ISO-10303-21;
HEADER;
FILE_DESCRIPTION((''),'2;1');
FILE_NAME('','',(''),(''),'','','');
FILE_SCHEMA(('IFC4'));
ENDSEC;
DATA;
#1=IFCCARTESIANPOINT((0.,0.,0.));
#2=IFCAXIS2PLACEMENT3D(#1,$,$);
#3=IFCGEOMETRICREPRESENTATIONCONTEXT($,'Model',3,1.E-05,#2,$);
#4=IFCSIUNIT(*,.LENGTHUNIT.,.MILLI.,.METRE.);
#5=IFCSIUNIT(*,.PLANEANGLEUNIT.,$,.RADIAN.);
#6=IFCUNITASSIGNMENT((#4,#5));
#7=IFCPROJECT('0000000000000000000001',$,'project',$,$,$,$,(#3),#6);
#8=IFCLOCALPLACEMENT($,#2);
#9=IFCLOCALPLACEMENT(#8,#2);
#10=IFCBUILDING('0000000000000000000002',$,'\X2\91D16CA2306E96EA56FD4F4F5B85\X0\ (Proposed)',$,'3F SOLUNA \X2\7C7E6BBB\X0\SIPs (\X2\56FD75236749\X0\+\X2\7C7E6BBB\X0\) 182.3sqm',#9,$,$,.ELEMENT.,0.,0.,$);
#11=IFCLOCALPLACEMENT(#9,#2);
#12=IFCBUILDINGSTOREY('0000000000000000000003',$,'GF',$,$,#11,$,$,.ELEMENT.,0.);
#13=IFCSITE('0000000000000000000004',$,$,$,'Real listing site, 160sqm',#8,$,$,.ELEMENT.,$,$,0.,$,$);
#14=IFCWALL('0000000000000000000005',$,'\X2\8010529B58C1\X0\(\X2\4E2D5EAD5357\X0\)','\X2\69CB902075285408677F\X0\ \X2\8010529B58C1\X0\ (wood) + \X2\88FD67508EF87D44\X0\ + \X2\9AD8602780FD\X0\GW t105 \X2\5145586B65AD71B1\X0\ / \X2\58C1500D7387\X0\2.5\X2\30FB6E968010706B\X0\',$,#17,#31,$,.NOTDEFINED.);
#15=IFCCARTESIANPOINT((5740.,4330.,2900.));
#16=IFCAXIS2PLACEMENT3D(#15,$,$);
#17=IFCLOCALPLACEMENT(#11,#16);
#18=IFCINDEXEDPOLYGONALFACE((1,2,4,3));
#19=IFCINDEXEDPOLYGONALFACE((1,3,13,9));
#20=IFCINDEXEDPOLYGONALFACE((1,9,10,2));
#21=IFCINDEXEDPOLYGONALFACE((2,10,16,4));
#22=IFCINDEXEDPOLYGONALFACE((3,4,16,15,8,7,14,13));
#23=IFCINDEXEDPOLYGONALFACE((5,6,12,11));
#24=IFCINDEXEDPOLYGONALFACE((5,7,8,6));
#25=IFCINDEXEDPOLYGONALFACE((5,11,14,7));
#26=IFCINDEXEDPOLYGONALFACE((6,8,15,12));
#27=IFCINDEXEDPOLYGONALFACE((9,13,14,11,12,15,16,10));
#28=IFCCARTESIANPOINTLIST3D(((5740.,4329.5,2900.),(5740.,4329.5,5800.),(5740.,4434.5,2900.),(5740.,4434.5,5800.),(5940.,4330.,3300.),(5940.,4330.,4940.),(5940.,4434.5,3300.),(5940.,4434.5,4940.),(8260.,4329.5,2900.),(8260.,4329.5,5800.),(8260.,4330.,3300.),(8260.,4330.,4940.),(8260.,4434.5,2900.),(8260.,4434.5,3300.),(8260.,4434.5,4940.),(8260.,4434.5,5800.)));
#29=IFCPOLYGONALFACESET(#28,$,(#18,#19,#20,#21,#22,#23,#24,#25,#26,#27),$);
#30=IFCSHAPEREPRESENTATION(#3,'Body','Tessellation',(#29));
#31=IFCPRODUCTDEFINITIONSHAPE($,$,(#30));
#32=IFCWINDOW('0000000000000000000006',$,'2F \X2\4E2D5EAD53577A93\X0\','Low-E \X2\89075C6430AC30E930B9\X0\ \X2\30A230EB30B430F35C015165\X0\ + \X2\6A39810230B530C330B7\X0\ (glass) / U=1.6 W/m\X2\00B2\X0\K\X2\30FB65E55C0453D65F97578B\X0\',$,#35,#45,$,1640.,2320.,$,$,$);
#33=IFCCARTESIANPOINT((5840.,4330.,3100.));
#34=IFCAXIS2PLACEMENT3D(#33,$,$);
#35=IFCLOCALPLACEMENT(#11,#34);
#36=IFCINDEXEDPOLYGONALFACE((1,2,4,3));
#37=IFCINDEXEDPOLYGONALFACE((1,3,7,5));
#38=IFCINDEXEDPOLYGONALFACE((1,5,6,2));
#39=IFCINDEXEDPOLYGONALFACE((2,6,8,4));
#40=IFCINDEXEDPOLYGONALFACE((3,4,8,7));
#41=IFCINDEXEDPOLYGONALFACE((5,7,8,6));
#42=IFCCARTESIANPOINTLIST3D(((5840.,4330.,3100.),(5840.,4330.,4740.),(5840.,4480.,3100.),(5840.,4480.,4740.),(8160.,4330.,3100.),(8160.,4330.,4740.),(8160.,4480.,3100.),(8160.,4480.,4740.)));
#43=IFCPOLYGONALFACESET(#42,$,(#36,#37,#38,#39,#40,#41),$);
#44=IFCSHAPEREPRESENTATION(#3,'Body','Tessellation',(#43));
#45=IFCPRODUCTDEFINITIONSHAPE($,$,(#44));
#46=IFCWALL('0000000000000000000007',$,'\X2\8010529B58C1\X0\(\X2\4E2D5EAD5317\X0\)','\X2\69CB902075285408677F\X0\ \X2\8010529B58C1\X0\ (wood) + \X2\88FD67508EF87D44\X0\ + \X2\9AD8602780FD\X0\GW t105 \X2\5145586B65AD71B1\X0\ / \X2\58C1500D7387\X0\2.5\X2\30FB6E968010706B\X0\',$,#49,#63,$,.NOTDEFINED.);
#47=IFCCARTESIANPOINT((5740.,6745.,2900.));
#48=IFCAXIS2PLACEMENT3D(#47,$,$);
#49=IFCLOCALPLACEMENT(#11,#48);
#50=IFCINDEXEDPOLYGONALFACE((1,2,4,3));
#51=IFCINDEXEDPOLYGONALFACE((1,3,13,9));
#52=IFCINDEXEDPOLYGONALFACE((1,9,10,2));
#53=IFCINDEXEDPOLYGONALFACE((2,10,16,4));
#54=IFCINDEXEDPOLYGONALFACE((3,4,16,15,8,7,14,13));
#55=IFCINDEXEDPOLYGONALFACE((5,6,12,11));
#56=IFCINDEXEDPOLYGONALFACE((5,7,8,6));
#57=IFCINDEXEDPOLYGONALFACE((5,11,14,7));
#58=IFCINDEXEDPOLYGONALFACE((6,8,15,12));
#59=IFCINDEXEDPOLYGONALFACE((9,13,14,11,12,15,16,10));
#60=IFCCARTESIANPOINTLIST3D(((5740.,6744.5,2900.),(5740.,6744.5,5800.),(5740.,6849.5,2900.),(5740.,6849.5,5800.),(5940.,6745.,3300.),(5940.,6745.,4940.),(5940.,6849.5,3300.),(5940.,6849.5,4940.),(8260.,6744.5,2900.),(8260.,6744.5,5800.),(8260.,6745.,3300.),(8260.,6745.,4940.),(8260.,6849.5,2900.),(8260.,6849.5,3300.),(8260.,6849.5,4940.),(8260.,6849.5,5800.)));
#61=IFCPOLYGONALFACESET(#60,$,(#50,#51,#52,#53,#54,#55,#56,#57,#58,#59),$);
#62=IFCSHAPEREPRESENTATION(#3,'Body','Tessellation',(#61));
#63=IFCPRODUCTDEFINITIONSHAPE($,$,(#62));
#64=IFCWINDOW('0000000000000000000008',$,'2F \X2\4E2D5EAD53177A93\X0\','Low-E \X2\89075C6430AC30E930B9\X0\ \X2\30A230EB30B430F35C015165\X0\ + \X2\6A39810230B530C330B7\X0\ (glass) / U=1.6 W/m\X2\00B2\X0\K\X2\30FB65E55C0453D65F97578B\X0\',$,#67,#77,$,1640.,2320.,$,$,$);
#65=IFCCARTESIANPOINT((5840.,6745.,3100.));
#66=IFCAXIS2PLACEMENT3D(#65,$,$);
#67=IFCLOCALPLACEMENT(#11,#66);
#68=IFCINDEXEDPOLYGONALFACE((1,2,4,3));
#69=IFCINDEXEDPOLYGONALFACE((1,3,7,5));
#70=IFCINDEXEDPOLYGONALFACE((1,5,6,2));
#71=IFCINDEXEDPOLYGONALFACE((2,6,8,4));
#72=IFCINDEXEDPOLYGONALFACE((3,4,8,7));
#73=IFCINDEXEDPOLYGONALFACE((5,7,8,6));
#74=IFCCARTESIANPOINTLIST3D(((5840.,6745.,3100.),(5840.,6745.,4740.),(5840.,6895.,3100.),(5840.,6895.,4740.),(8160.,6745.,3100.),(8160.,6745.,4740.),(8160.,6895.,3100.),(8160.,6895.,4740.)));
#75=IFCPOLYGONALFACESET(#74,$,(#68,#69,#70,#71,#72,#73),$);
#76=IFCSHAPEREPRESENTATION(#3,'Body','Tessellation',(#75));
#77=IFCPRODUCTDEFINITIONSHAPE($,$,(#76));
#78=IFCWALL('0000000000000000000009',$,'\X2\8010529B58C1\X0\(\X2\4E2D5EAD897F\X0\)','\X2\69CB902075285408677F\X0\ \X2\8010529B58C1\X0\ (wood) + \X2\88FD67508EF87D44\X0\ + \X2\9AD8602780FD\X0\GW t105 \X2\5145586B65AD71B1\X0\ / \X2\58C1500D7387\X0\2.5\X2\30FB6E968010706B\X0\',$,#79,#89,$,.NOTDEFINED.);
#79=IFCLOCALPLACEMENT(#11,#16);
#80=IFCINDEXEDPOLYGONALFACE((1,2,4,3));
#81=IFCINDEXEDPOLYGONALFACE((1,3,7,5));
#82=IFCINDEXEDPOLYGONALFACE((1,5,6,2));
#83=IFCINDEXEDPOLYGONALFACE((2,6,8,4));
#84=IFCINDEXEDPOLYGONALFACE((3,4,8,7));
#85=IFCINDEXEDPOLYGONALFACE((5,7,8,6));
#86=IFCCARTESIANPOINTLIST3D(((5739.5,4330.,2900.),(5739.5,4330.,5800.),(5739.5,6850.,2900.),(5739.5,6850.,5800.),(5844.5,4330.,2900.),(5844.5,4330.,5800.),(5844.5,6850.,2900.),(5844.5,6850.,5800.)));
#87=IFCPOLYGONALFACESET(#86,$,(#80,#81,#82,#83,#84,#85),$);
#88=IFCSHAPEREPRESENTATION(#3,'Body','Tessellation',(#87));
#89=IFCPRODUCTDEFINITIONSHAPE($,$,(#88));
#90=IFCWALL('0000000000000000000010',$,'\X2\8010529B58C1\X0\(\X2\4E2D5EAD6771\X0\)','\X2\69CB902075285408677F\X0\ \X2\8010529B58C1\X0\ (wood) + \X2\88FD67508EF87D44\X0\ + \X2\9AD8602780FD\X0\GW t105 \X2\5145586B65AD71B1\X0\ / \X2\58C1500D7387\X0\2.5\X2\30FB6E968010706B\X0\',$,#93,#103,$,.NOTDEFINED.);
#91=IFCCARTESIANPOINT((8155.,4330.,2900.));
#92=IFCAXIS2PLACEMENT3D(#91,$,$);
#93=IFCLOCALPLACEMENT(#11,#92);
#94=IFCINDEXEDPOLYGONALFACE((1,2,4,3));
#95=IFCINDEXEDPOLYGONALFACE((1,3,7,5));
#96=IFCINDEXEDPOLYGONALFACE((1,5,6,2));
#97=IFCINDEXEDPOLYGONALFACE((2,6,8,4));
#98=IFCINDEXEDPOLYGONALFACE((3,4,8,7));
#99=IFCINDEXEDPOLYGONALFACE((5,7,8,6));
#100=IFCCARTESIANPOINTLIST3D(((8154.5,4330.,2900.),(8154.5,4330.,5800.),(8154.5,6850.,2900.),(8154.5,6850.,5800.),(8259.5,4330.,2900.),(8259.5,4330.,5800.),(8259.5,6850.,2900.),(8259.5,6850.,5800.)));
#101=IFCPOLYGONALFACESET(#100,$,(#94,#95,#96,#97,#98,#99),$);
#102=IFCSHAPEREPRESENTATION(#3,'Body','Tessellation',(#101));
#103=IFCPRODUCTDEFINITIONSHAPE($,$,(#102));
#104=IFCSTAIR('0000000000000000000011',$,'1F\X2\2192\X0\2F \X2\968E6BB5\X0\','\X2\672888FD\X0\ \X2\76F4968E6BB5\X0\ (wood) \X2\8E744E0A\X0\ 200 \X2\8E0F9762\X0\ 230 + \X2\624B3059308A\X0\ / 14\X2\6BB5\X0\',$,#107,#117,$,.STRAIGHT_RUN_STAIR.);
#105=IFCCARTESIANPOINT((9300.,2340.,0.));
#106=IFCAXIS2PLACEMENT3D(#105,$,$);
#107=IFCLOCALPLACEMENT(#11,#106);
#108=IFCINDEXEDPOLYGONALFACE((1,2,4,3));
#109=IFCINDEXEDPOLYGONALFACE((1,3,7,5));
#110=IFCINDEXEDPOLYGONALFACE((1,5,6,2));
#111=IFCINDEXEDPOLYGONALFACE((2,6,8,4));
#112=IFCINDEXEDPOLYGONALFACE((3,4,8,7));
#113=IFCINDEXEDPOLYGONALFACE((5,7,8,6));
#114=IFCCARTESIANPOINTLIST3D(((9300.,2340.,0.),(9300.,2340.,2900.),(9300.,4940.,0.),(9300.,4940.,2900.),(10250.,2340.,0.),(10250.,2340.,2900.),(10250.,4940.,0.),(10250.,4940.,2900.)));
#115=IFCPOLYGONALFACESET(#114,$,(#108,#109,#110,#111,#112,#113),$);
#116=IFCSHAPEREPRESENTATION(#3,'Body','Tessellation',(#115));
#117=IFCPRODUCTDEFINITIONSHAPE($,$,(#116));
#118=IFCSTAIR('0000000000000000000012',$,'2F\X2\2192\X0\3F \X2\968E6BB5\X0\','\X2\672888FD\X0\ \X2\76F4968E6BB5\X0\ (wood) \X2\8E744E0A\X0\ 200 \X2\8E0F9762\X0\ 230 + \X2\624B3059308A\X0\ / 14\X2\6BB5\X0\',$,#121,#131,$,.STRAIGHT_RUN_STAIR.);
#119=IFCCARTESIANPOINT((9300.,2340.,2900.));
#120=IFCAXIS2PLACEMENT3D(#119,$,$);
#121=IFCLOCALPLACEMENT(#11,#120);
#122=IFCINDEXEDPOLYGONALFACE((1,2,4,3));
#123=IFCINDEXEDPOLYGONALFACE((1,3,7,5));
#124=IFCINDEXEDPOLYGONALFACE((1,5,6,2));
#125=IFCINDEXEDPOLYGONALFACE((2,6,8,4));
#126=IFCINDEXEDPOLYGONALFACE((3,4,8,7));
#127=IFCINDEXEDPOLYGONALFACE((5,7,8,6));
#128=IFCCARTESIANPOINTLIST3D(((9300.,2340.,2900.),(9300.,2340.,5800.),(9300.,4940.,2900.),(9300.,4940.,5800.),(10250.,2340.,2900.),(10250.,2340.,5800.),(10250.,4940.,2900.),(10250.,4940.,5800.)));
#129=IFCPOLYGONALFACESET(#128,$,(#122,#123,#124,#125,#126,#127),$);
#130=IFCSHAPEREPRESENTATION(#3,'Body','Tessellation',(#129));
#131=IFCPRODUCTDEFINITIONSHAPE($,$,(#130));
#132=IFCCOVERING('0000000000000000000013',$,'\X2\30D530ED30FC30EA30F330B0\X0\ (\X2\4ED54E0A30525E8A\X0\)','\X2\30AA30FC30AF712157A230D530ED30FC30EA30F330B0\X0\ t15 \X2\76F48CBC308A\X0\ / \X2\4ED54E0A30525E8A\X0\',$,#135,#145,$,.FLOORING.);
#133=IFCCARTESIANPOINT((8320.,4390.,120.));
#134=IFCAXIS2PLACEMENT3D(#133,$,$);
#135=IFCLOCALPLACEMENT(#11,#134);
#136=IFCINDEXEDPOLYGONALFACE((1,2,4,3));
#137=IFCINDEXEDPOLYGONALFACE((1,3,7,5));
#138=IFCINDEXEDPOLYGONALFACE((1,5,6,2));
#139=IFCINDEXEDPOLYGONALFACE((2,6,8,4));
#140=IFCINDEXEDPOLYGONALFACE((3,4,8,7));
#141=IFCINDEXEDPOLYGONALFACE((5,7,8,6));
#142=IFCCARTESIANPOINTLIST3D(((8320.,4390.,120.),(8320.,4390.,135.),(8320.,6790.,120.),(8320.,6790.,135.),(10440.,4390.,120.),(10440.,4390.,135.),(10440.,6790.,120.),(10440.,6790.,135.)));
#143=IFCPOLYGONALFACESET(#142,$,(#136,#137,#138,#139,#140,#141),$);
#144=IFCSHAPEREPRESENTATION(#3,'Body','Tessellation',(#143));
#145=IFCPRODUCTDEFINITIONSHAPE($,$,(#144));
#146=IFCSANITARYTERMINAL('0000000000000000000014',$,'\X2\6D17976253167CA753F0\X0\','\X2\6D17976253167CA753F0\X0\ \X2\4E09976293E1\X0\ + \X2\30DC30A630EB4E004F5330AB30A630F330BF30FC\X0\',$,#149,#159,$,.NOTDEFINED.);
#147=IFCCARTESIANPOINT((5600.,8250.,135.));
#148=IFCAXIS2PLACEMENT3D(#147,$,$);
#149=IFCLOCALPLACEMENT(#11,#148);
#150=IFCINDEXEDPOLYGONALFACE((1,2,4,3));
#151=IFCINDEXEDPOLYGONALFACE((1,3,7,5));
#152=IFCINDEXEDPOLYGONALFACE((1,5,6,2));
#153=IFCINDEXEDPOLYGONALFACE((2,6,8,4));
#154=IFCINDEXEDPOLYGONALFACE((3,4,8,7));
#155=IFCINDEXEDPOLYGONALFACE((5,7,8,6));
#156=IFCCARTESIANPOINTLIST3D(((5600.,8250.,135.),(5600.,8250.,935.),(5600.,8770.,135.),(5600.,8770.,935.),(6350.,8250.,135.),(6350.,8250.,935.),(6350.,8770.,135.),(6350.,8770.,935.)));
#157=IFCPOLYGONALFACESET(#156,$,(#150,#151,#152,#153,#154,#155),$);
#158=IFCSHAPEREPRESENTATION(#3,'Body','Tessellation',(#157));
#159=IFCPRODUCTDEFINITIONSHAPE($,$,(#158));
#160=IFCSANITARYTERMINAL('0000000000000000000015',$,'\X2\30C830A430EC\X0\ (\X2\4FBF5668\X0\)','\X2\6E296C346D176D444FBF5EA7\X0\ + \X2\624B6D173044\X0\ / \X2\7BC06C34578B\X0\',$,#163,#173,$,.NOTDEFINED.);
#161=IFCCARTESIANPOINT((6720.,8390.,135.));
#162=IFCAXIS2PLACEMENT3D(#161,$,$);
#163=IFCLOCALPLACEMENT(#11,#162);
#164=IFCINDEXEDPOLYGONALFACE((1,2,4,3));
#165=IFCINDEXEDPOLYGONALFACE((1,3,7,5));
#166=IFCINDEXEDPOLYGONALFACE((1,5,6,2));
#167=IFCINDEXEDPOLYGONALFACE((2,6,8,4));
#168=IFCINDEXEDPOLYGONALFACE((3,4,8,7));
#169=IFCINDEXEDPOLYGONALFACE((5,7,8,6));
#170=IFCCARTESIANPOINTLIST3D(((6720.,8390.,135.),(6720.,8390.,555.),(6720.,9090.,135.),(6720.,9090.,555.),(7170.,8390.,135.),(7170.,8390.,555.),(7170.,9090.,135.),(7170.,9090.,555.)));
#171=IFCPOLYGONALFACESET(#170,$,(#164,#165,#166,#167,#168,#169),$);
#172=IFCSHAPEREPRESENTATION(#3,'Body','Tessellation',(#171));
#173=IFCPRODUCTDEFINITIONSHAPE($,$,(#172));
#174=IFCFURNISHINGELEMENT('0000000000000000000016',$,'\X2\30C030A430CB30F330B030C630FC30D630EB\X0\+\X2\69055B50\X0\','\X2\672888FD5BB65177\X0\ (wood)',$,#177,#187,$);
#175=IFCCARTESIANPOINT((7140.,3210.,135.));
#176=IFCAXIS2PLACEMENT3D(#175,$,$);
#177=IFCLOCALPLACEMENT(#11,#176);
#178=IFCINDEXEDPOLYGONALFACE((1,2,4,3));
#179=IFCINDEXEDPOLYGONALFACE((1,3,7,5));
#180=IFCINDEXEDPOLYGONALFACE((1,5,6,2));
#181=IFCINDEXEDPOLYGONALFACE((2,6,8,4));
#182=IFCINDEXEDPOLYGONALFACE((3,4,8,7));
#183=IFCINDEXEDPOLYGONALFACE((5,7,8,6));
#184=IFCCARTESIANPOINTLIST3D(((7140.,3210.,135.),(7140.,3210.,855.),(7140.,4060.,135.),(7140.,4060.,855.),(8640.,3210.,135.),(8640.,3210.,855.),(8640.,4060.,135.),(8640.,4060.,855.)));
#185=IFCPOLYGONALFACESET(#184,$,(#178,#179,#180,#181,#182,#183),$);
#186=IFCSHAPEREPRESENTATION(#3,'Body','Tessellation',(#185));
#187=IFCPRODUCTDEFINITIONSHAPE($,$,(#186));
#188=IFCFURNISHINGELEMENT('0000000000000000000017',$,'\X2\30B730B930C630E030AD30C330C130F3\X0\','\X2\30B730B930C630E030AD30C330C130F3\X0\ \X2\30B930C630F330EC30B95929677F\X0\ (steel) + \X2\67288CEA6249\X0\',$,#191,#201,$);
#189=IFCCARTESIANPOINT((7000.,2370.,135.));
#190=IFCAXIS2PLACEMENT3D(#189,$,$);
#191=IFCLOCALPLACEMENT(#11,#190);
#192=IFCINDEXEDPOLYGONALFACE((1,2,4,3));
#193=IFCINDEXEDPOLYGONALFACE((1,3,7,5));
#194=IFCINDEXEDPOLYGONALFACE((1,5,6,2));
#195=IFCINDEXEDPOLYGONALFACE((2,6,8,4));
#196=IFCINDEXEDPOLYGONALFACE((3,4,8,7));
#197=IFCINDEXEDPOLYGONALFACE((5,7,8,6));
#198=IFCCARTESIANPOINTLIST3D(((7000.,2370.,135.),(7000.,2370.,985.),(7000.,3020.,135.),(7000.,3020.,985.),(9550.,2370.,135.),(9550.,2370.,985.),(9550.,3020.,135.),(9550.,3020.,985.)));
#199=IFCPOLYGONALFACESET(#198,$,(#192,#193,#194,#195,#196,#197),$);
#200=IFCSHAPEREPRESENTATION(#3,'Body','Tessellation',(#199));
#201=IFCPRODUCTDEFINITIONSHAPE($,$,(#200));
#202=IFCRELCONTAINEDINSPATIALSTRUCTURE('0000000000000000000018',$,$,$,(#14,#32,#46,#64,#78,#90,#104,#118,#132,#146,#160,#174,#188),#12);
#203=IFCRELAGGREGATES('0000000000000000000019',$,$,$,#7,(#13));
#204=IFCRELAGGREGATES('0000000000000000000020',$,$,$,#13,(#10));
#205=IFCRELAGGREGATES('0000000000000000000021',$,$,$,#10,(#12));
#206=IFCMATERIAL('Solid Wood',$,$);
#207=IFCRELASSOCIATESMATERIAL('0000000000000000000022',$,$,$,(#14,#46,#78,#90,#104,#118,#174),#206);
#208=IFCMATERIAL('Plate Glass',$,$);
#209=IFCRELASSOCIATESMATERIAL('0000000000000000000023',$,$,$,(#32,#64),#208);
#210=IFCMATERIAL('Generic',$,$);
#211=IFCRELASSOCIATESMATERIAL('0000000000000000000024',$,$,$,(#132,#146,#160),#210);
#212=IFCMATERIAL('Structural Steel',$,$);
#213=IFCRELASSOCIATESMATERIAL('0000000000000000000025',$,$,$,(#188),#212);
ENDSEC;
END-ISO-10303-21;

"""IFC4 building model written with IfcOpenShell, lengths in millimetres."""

from ifc_helpers import new_model, si_unit, frame, frame_2d, origin, place, context, project, spatial, rectangle, extrude, material, element, fill, save


model = new_model("IFC4")

# Units and contexts
model_context = context("Model", 3, precision=1e-05, world=origin())
ifc_project = project(units=[si_unit("LENGTHUNIT", "METRE", prefix="MILLI"), si_unit("PLANEANGLEUNIT", "RADIAN")], contexts=[model_context])

# Site, building, storey
site_placement = place(None, origin())
site = spatial("IfcSite", under=ifc_project, at=site_placement, ObjectType="Real listing site, 160sqm", CompositionType="ELEMENT", RefElevation=0.0)
building_placement = place(site_placement, origin())
building = spatial("IfcBuilding", under=site, at=building_placement, Name="金沢の雪国住宅 (Proposed)", ObjectType="3F SOLUNA 籾殻SIPs (国産杉+籾殻) 182.3sqm", CompositionType="ELEMENT", ElevationOfRefHeight=0.0, ElevationOfTerrain=0.0)
storey_placement = place(building_placement, origin())
storey = spatial("IfcBuildingStorey", under=building, at=storey_placement, Name="GF", CompositionType="ELEMENT", Elevation=0.0)

# Shared definitions
ifc_material_1 = material(Name="Solid Wood")

# Shared definitions
ifc_material_2 = material(Name="Plate Glass")

# Walls, openings, windows
wall_1_placement = place(storey_placement, frame((5740.0, 4330.0, 2900.0)))
wall_1 = element("IfcWall", 1, at=wall_1_placement, inside=storey, material=ifc_material_1, Name="耐力壁(中庭南)", Description="構造用合板 耐力壁 (wood) + 製材軸組 + 高性能GW t105 充填断熱 / 壁倍率2.5・準耐火", PredefinedType="NOTDEFINED", context=model_context, shape_type="SweptSolid", body=[
    extrude(rectangle(XDim=2520.0, YDim=105.0, at=frame_2d((1260.0, 52.0))), frame((5740.0, 4330.0, 2900.0)), (0.0, 0.0, 1.0), 2900.0),
])
opening_1_placement = place(storey_placement, frame((5840.0, 4330.0, 3100.0)))
opening_1 = element("IfcOpeningElement", 2, at=opening_1_placement, cuts=wall_1, PredefinedType="NOTDEFINED", context=model_context, shape_type="SweptSolid", body=[
    extrude(rectangle(XDim=2320.0, YDim=150.0, at=frame_2d((1160.0, 75.0))), frame((5840.0, 4330.0, 3100.0)), (0.0, 0.0, 1.0), 1640.0),
])
window_1_placement = place(storey_placement, frame((5840.0, 4330.0, 3100.0)))
window_1 = element("IfcWindow", 3, at=window_1_placement, inside=storey, material=ifc_material_2, Name="2F 中庭南窓", Description="Low-E 複層ガラス アルゴン封入 + 樹脂サッシ (glass) / U=1.6 W/m²K・日射取得型", OverallHeight=1640.0, OverallWidth=2320.0, context=model_context, shape_type="SweptSolid", body=[
    extrude(rectangle(XDim=2320.0, YDim=150.0, at=frame_2d((1160.0, 75.0))), frame((5840.0, 4330.0, 3100.0)), (0.0, 0.0, 1.0), 1640.0),
])
fill(opening_1, window_1)
wall_2_placement = place(storey_placement, frame((5740.0, 6745.0, 2900.0)))
wall_2 = element("IfcWall", 4, at=wall_2_placement, inside=storey, material=ifc_material_1, Name="耐力壁(中庭北)", Description="構造用合板 耐力壁 (wood) + 製材軸組 + 高性能GW t105 充填断熱 / 壁倍率2.5・準耐火", PredefinedType="NOTDEFINED", context=model_context, shape_type="SweptSolid", body=[
    extrude(rectangle(XDim=2520.0, YDim=105.0, at=frame_2d((1260.0, 52.0))), frame((5740.0, 6745.0, 2900.0)), (0.0, 0.0, 1.0), 2900.0),
])
opening_2_placement = place(storey_placement, frame((5840.0, 6745.0, 3100.0)))
opening_2 = element("IfcOpeningElement", 5, at=opening_2_placement, cuts=wall_2, PredefinedType="NOTDEFINED", context=model_context, shape_type="SweptSolid", body=[
    extrude(rectangle(XDim=2320.0, YDim=150.0, at=frame_2d((1160.0, 75.0))), frame((5840.0, 6745.0, 3100.0)), (0.0, 0.0, 1.0), 1640.0),
])
window_2_placement = place(storey_placement, frame((5840.0, 6745.0, 3100.0)))
window_2 = element("IfcWindow", 6, at=window_2_placement, inside=storey, material=ifc_material_2, Name="2F 中庭北窓", Description="Low-E 複層ガラス アルゴン封入 + 樹脂サッシ (glass) / U=1.6 W/m²K・日射取得型", OverallHeight=1640.0, OverallWidth=2320.0, context=model_context, shape_type="SweptSolid", body=[
    extrude(rectangle(XDim=2320.0, YDim=150.0, at=frame_2d((1160.0, 75.0))), frame((5840.0, 6745.0, 3100.0)), (0.0, 0.0, 1.0), 1640.0),
])
fill(opening_2, window_2)

# Walls
wall_3_placement = place(storey_placement, frame((5740.0, 4330.0, 2900.0)))
element("IfcWall", 7, at=wall_3_placement, inside=storey, material=ifc_material_1, Name="耐力壁(中庭西)", Description="構造用合板 耐力壁 (wood) + 製材軸組 + 高性能GW t105 充填断熱 / 壁倍率2.5・準耐火", PredefinedType="NOTDEFINED", context=model_context, shape_type="SweptSolid", body=[
    extrude(rectangle(XDim=105.0, YDim=2520.0, at=frame_2d((52.0, 1260.0))), frame((5740.0, 4330.0, 2900.0)), (0.0, 0.0, 1.0), 2900.0),
])
wall_4_placement = place(storey_placement, frame((8155.0, 4330.0, 2900.0)))
element("IfcWall", 8, at=wall_4_placement, inside=storey, material=ifc_material_1, Name="耐力壁(中庭東)", Description="構造用合板 耐力壁 (wood) + 製材軸組 + 高性能GW t105 充填断熱 / 壁倍率2.5・準耐火", PredefinedType="NOTDEFINED", context=model_context, shape_type="SweptSolid", body=[
    extrude(rectangle(XDim=105.0, YDim=2520.0, at=frame_2d((52.0, 1260.0))), frame((8155.0, 4330.0, 2900.0)), (0.0, 0.0, 1.0), 2900.0),
])

# Stairs
stair_1_placement = place(storey_placement, frame((9300.0, 2340.0, 0.0)))
element("IfcStair", 9, at=stair_1_placement, inside=storey, material=ifc_material_1, Name="1F→2F 階段", Description="木製 直階段 (wood) 蹴上 200 踏面 230 + 手すり / 14段", PredefinedType="STRAIGHT_RUN_STAIR", context=model_context, shape_type="SweptSolid", body=[
    extrude(rectangle(XDim=950.0, YDim=2600.0, at=frame_2d((475.0, 1300.0))), frame((9300.0, 2340.0, 0.0)), (0.0, 0.0, 1.0), 2900.0),
])
stair_2_placement = place(storey_placement, frame((9300.0, 2340.0, 2900.0)))
element("IfcStair", 10, at=stair_2_placement, inside=storey, material=ifc_material_1, Name="2F→3F 階段", Description="木製 直階段 (wood) 蹴上 200 踏面 230 + 手すり / 14段", PredefinedType="STRAIGHT_RUN_STAIR", context=model_context, shape_type="SweptSolid", body=[
    extrude(rectangle(XDim=950.0, YDim=2600.0, at=frame_2d((475.0, 1300.0))), frame((9300.0, 2340.0, 2900.0)), (0.0, 0.0, 1.0), 2900.0),
])

# Covering
ifc_material_3 = material(Name="Generic")
covering_placement = place(storey_placement, frame((8320.0, 4390.0, 120.0)))
element("IfcCovering", 11, at=covering_placement, inside=storey, material=ifc_material_3, Name="フローリング (仕上げ床)", Description="オーク無垢フローリング t15 直貼り / 仕上げ床", PredefinedType="FLOORING", context=model_context, shape_type="SweptSolid", body=[
    extrude(rectangle(XDim=2120.0, YDim=2400.0, at=frame_2d((1060.0, 1200.0))), frame((8320.0, 4390.0, 120.0)), (0.0, 0.0, 1.0), 15.0),
])

# Sanitary terminals
sanitary_terminal_1_placement = place(storey_placement, frame((5600.0, 8250.0, 135.0)))
element("IfcSanitaryTerminal", 12, at=sanitary_terminal_1_placement, inside=storey, material=ifc_material_3, Name="洗面化粧台", Description="洗面化粧台 三面鏡 + ボウル一体カウンター", PredefinedType="NOTDEFINED", context=model_context, shape_type="SweptSolid", body=[
    extrude(rectangle(XDim=750.0, YDim=520.0, at=frame_2d((375.0, 260.0))), frame((5600.0, 8250.0, 135.0)), (0.0, 0.0, 1.0), 800.0),
])
sanitary_terminal_2_placement = place(storey_placement, frame((6720.0, 8390.0, 135.0)))
element("IfcSanitaryTerminal", 13, at=sanitary_terminal_2_placement, inside=storey, material=ifc_material_3, Name="トイレ (便器)", Description="温水洗浄便座 + 手洗い / 節水型", PredefinedType="NOTDEFINED", context=model_context, shape_type="SweptSolid", body=[
    extrude(rectangle(XDim=450.0, YDim=700.0, at=frame_2d((225.0, 350.0))), frame((6720.0, 8390.0, 135.0)), (0.0, 0.0, 1.0), 420.0),
])

# Furnishing elements
furnishing_1_placement = place(storey_placement, frame((7140.0, 3210.0, 135.0)))
element("IfcFurnishingElement", 14, at=furnishing_1_placement, inside=storey, material=ifc_material_1, Name="ダイニングテーブル+椅子", Description="木製家具 (wood)", context=model_context, shape_type="SweptSolid", body=[
    extrude(rectangle(XDim=1500.0, YDim=850.0, at=frame_2d((750.0, 425.0))), frame((7140.0, 3210.0, 135.0)), (0.0, 0.0, 1.0), 720.0),
])
ifc_material_4 = material(Name="Structural Steel")
furnishing_2_placement = place(storey_placement, frame((7000.0, 2370.0, 135.0)))
element("IfcFurnishingElement", 15, at=furnishing_2_placement, inside=storey, material=ifc_material_4, Name="システムキッチン", Description="システムキッチン ステンレス天板 (steel) + 木質扉", context=model_context, shape_type="SweptSolid", body=[
    extrude(rectangle(XDim=2550.0, YDim=650.0, at=frame_2d((1275.0, 325.0))), frame((7000.0, 2370.0, 135.0)), (0.0, 0.0, 1.0), 850.0),
])

save(model, "model.ifc")
